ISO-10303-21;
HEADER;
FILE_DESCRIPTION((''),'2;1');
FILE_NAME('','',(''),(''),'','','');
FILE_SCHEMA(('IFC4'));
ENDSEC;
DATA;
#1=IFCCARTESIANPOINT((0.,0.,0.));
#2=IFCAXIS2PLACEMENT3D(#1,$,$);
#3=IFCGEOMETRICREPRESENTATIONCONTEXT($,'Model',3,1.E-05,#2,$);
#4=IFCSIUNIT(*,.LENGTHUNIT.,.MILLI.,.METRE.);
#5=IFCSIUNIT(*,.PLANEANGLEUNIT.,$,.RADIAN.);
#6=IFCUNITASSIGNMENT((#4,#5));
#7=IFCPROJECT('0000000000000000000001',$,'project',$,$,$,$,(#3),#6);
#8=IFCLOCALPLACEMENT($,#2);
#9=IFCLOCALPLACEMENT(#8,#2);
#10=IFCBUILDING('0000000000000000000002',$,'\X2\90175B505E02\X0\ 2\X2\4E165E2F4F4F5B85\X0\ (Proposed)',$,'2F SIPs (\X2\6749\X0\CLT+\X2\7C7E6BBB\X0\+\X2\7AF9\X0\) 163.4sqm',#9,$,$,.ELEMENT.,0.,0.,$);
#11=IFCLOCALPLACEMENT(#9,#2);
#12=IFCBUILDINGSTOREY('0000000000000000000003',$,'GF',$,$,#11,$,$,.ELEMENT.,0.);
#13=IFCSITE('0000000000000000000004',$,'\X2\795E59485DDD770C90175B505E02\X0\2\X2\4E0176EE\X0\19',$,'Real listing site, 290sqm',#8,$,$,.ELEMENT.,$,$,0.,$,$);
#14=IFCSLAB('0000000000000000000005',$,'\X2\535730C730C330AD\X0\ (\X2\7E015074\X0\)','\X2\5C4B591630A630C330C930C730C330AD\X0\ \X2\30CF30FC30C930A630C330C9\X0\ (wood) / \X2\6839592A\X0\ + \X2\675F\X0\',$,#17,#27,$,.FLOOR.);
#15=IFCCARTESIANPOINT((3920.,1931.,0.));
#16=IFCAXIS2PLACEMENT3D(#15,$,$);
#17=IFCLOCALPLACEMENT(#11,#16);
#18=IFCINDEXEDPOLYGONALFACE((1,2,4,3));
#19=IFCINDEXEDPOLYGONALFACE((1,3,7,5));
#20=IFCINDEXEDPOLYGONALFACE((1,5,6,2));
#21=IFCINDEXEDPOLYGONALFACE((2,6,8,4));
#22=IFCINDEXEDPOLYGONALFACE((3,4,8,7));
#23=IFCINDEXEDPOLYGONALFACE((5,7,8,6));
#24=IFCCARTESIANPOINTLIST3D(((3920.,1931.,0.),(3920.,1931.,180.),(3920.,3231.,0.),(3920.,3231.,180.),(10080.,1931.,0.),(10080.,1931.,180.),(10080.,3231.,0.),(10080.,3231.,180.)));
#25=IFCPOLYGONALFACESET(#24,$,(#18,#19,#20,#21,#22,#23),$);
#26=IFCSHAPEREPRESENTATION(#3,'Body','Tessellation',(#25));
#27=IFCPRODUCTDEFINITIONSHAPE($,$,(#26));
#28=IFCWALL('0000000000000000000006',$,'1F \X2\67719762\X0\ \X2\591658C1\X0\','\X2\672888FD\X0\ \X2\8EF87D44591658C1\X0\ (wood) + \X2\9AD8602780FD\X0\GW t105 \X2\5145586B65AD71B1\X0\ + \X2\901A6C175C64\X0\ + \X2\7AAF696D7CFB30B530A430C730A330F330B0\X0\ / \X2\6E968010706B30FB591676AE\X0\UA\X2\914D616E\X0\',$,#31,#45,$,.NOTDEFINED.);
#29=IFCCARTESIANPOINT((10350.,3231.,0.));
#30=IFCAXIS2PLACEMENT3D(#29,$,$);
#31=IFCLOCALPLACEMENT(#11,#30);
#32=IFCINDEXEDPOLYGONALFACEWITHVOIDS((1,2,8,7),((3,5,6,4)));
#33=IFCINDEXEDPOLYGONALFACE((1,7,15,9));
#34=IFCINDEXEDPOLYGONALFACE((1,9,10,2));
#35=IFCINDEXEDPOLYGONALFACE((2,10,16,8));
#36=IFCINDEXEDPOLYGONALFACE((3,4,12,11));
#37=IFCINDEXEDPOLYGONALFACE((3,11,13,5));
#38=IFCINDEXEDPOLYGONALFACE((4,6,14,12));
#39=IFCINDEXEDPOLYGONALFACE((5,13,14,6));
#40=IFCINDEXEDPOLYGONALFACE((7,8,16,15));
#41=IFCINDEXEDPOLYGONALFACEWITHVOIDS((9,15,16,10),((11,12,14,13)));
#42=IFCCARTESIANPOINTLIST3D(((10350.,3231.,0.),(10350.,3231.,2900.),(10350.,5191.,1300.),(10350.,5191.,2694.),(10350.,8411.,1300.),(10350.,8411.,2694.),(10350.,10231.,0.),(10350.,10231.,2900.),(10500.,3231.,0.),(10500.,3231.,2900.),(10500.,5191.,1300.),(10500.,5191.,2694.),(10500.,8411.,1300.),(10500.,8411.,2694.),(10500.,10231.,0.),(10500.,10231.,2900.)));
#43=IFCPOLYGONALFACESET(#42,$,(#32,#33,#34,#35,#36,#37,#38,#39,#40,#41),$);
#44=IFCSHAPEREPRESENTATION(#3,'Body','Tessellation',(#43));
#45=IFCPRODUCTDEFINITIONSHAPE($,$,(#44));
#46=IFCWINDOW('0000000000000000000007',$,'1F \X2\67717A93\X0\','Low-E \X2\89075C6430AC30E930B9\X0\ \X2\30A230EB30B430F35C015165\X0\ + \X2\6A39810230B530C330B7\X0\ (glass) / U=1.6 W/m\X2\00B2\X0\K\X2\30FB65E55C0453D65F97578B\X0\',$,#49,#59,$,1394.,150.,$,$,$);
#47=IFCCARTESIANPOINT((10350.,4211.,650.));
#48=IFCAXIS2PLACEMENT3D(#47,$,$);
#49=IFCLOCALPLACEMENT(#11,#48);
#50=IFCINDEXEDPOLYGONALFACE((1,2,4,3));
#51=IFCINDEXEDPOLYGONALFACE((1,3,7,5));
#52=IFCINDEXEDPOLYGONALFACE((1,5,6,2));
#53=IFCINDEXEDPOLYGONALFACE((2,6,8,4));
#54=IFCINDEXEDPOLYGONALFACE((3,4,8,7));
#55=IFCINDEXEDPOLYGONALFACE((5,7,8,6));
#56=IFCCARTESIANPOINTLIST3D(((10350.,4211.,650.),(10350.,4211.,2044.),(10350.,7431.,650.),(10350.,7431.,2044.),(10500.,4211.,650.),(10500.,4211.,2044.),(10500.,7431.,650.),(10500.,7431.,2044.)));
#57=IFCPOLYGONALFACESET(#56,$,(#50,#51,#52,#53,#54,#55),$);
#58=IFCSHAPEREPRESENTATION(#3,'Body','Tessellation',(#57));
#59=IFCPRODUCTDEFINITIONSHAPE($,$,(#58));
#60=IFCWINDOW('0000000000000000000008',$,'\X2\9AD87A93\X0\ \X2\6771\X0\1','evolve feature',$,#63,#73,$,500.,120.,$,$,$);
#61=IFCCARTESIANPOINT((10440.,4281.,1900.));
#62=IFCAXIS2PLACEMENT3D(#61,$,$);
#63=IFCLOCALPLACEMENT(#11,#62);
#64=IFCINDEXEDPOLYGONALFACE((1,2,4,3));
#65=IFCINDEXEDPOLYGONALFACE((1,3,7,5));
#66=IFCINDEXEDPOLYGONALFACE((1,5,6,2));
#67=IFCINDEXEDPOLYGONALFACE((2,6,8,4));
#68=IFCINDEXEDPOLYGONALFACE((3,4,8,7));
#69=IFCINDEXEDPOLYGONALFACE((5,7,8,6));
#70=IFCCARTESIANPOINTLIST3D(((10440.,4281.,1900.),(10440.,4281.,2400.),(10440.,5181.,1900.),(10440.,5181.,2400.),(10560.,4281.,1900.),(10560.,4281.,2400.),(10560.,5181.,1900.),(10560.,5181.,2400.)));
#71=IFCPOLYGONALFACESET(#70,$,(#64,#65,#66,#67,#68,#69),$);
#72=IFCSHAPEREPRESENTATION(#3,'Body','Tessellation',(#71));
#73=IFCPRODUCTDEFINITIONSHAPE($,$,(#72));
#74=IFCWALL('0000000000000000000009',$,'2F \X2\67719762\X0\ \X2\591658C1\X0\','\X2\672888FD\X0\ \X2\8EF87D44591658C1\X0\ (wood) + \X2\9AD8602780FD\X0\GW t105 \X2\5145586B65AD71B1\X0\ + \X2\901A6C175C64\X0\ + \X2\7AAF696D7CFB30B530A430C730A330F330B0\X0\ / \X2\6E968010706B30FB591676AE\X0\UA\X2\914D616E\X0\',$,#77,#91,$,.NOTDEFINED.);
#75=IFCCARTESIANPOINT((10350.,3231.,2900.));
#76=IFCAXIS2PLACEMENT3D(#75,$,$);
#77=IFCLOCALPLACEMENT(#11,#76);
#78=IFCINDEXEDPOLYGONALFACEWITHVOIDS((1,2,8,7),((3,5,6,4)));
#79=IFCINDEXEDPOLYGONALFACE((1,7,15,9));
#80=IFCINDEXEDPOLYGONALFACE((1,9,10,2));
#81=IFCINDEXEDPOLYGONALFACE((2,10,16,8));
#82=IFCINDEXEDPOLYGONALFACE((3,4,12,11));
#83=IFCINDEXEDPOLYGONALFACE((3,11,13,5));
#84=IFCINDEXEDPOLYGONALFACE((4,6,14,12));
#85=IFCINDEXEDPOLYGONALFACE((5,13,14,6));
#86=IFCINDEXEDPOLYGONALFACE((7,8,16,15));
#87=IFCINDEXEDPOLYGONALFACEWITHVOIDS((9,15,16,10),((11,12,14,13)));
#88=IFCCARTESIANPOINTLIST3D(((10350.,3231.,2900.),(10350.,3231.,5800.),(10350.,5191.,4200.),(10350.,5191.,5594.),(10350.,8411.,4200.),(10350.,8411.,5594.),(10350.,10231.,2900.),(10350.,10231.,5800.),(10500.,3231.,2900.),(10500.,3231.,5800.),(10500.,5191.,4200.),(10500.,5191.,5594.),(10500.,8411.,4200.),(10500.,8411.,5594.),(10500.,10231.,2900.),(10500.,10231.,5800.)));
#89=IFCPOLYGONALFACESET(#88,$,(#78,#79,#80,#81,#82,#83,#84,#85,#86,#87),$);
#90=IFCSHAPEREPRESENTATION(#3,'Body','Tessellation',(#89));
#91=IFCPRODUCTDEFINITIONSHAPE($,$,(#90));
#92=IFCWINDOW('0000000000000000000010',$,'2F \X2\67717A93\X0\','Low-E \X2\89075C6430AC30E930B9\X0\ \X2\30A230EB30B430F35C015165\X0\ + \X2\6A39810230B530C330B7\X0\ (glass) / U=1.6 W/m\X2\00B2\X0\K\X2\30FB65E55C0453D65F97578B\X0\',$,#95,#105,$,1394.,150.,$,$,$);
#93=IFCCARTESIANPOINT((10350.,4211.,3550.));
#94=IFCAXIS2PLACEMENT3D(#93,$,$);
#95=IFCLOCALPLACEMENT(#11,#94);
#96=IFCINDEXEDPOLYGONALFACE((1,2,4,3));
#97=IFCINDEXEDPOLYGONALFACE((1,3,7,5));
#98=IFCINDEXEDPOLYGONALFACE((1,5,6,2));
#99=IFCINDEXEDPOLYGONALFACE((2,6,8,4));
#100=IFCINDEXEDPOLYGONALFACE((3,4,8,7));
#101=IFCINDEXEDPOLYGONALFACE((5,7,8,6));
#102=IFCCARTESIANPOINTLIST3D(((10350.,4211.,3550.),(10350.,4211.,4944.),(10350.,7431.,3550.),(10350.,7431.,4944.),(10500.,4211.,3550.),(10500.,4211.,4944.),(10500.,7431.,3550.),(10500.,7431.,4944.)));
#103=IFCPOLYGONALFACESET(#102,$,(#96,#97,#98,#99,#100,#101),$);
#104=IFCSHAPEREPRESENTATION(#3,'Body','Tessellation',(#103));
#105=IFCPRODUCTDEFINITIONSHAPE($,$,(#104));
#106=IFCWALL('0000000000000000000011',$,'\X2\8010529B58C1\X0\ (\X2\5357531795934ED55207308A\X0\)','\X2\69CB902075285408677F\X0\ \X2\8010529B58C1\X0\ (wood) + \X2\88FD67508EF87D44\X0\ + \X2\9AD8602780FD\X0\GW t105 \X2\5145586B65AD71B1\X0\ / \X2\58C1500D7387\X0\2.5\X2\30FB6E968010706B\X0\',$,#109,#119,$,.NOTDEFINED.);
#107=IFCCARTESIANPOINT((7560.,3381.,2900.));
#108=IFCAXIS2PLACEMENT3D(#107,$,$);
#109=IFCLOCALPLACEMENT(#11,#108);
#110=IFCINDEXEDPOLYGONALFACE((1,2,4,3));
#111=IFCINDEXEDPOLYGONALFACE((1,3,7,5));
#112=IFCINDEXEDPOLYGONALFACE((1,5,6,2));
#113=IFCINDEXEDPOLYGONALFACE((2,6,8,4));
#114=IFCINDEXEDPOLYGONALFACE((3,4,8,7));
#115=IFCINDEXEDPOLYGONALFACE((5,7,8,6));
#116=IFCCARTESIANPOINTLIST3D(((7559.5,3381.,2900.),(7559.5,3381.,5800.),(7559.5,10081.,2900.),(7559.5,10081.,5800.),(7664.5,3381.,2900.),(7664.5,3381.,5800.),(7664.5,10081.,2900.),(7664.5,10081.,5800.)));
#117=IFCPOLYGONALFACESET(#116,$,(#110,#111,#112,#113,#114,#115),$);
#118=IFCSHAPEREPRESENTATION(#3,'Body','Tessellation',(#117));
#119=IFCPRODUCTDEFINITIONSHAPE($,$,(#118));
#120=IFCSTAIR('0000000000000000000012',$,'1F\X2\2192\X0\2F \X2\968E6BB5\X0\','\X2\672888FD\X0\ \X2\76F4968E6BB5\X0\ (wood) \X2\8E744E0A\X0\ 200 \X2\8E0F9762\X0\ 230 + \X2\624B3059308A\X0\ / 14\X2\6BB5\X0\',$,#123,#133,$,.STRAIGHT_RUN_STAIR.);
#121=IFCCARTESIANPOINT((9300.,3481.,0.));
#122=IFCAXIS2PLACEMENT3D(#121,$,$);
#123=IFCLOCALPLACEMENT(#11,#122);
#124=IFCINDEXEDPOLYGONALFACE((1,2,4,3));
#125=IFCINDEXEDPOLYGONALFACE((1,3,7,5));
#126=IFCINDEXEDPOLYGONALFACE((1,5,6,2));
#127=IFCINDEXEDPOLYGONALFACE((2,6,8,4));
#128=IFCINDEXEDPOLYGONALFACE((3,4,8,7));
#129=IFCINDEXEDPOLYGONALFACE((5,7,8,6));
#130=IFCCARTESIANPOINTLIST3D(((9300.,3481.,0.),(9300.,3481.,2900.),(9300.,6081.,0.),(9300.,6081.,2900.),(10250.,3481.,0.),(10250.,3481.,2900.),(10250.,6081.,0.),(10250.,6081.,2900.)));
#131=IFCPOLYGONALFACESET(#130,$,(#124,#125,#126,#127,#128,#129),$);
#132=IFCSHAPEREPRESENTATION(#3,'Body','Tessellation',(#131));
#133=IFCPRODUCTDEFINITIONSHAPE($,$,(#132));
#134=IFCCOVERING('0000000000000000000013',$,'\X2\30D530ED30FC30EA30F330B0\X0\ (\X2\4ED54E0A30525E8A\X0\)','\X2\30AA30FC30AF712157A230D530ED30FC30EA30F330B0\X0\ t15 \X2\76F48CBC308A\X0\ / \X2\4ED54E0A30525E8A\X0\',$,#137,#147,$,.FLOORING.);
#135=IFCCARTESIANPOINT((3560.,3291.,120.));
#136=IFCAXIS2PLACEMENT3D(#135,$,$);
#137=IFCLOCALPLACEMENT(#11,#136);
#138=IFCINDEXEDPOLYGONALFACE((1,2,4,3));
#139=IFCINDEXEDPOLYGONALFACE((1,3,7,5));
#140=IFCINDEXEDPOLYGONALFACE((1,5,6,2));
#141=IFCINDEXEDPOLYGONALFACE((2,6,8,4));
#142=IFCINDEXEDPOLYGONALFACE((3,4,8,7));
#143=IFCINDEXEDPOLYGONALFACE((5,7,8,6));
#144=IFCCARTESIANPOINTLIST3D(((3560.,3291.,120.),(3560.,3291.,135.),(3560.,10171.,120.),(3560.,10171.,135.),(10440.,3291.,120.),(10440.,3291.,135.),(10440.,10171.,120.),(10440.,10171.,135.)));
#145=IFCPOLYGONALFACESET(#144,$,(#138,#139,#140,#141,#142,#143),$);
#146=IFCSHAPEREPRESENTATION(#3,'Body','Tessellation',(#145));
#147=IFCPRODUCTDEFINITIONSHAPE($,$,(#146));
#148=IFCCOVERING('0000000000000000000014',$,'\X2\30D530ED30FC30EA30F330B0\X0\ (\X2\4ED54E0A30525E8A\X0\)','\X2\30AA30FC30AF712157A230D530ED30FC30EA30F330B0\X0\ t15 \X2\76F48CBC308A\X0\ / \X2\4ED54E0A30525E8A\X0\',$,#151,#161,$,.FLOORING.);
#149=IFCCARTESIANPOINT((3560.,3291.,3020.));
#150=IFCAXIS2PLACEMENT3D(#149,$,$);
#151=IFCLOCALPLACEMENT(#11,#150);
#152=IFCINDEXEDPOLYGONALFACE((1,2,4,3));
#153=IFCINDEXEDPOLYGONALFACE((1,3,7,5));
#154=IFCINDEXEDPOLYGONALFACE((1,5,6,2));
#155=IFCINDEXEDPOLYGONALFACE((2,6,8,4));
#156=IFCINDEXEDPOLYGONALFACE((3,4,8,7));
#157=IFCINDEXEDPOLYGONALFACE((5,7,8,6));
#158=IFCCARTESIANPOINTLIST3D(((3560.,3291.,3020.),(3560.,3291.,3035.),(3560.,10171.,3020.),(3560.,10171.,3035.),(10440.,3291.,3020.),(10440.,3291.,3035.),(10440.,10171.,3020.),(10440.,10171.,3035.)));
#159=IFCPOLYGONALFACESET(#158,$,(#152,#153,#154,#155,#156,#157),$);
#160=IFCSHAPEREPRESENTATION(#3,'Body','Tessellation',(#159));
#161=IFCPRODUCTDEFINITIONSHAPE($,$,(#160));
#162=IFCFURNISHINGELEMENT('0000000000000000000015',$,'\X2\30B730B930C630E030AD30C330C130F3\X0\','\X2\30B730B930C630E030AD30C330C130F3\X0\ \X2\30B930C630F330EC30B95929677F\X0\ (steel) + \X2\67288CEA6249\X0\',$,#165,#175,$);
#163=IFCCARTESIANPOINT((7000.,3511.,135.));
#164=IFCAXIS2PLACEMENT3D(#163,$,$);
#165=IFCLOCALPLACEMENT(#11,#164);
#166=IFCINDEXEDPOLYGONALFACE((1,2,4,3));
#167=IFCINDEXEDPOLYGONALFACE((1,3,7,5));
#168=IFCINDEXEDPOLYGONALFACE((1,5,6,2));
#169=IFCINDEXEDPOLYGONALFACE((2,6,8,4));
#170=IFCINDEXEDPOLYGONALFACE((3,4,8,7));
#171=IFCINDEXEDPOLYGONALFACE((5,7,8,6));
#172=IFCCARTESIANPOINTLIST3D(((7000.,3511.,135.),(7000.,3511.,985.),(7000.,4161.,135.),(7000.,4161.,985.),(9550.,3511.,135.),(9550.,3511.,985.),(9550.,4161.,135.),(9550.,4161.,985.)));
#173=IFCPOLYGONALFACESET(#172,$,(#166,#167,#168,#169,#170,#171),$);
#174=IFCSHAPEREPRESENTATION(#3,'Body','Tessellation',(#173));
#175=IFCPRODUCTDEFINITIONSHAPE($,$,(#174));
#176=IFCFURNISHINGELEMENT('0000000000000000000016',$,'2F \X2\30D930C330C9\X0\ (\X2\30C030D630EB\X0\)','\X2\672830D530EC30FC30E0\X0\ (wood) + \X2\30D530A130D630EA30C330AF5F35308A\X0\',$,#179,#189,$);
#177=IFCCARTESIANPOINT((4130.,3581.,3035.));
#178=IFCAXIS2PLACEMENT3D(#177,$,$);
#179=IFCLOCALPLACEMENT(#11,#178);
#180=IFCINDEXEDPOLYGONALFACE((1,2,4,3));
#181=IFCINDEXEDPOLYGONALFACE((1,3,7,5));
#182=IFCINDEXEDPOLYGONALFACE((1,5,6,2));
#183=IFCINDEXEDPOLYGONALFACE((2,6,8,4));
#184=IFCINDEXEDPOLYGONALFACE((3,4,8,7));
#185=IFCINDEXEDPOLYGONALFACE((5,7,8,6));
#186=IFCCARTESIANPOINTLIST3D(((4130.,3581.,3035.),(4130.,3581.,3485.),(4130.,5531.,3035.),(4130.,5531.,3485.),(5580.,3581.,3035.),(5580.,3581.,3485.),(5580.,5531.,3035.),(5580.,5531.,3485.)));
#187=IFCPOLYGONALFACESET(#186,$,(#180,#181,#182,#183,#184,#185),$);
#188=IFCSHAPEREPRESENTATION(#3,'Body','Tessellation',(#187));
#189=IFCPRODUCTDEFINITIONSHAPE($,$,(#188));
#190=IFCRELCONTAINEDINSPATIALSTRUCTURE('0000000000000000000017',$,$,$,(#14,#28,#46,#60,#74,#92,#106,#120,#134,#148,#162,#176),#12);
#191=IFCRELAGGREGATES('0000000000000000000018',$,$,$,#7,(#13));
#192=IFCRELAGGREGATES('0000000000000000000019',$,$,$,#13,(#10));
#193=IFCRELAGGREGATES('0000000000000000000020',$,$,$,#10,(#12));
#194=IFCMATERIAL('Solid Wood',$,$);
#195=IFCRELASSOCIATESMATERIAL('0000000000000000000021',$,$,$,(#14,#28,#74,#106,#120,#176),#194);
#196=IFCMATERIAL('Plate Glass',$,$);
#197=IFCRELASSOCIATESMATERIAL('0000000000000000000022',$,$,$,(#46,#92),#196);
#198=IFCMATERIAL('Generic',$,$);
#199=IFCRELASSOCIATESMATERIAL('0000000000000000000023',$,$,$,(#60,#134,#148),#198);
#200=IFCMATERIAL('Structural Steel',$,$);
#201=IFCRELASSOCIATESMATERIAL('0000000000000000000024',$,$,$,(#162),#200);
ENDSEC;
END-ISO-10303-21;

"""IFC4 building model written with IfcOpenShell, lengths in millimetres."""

from ifc_helpers import new_model, si_unit, frame, frame_2d, origin, place, context, project, spatial, rectangle, extrude, material, element, fill, save


model = new_model("IFC4")

# Units and contexts
model_context = context("Model", 3, precision=1e-05, world=origin())
ifc_project = project(units=[si_unit("LENGTHUNIT", "METRE", prefix="MILLI"), si_unit("PLANEANGLEUNIT", "RADIAN")], contexts=[model_context])

# Site, building, storey
site_placement = place(None, origin())
site = spatial("IfcSite", under=ifc_project, at=site_placement, Name="神奈川県逗子市2丁目19", ObjectType="Real listing site, 290sqm", CompositionType="ELEMENT", RefElevation=0.0)
building_placement = place(site_placement, origin())
building = spatial("IfcBuilding", under=site, at=building_placement, Name="逗子市 2世帯住宅 (Proposed)", ObjectType="2F SIPs (杉CLT+籾殻+竹) 163.4sqm", CompositionType="ELEMENT", ElevationOfRefHeight=0.0, ElevationOfTerrain=0.0)
storey_placement = place(building_placement, origin())
storey = spatial("IfcBuildingStorey", under=building, at=storey_placement, Name="GF", CompositionType="ELEMENT", Elevation=0.0)

# Slab
ifc_material_1 = material(Name="Solid Wood")
slab_placement = place(storey_placement, frame((3920.0, 1931.0, 0.0)))
element("IfcSlab", 1, at=slab_placement, inside=storey, material=ifc_material_1, Name="南デッキ (縁側)", Description="屋外ウッドデッキ ハードウッド (wood) / 根太 + 束", PredefinedType="FLOOR", context=model_context, shape_type="SweptSolid", body=[
    extrude(rectangle(XDim=6160.0, YDim=1300.0, at=frame_2d((3080.0, 650.0))), frame((3920.0, 1931.0, 0.0)), (0.0, 0.0, 1.0), 180.0),
])

# Wall, openings, windows
wall_1_placement = place(storey_placement, frame((10350.0, 3231.0, 0.0)))
wall_1 = element("IfcWall", 2, at=wall_1_placement, inside=storey, material=ifc_material_1, Name="1F 東面 外壁", Description="木製 軸組外壁 (wood) + 高性能GW t105 充填断熱 + 通気層 + 窯業系サイディング / 準耐火・外皮UA配慮", PredefinedType="NOTDEFINED", context=model_context, shape_type="SweptSolid", body=[
    extrude(rectangle(XDim=150.0, YDim=7000.0, at=frame_2d((75.0, 3500.0))), frame((10350.0, 3231.0, 0.0)), (0.0, 0.0, 1.0), 2900.0),
])
opening_1_placement = place(storey_placement, frame((10350.0, 4211.0, 650.0)))
opening_1 = element("IfcOpeningElement", 3, at=opening_1_placement, cuts=wall_1, PredefinedType="NOTDEFINED", context=model_context, shape_type="SweptSolid", body=[
    extrude(rectangle(XDim=150.0, YDim=3220.0, at=frame_2d((75.0, 1610.0))), frame((10350.0, 4211.0, 650.0)), (0.0, 0.0, 1.0), 1394.0),
])
opening_2_placement = place(storey_placement, frame((10440.0, 4281.0, 1900.0)))
opening_2 = element("IfcOpeningElement", 4, at=opening_2_placement, cuts=wall_1, PredefinedType="NOTDEFINED", context=model_context, shape_type="SweptSolid", body=[
    extrude(rectangle(XDim=120.0, YDim=900.0, at=frame_2d((60.0, 450.0))), frame((10440.0, 4281.0, 1900.0)), (0.0, 0.0, 1.0), 500.0),
])
ifc_material_2 = material(Name="Plate Glass")
window_1_placement = place(storey_placement, frame((10350.0, 4211.0, 650.0)))
window_1 = element("IfcWindow", 5, at=window_1_placement, inside=storey, material=ifc_material_2, Name="1F 東窓", Description="Low-E 複層ガラス アルゴン封入 + 樹脂サッシ (glass) / U=1.6 W/m²K・日射取得型", OverallHeight=1394.0, OverallWidth=150.0, context=model_context, shape_type="SweptSolid", body=[
    extrude(rectangle(XDim=150.0, YDim=3220.0, at=frame_2d((75.0, 1610.0))), frame((10350.0, 4211.0, 650.0)), (0.0, 0.0, 1.0), 1394.0),
])
fill(opening_1, window_1)
ifc_material_3 = material(Name="Generic")
window_2_placement = place(storey_placement, frame((10440.0, 4281.0, 1900.0)))
window_2 = element("IfcWindow", 6, at=window_2_placement, inside=storey, material=ifc_material_3, Name="高窓 東1", Description="evolve feature", OverallHeight=500.0, OverallWidth=120.0, context=model_context, shape_type="SweptSolid", body=[
    extrude(rectangle(XDim=120.0, YDim=900.0, at=frame_2d((60.0, 450.0))), frame((10440.0, 4281.0, 1900.0)), (0.0, 0.0, 1.0), 500.0),
])
fill(opening_2, window_2)

# Wall, opening, window
wall_2_placement = place(storey_placement, frame((10350.0, 3231.0, 2900.0)))
wall_2 = element("IfcWall", 7, at=wall_2_placement, inside=storey, material=ifc_material_1, Name="2F 東面 外壁", Description="木製 軸組外壁 (wood) + 高性能GW t105 充填断熱 + 通気層 + 窯業系サイディング / 準耐火・外皮UA配慮", PredefinedType="NOTDEFINED", context=model_context, shape_type="SweptSolid", body=[
    extrude(rectangle(XDim=150.0, YDim=7000.0, at=frame_2d((75.0, 3500.0))), frame((10350.0, 3231.0, 2900.0)), (0.0, 0.0, 1.0), 2900.0),
])
opening_3_placement = place(storey_placement, frame((10350.0, 4211.0, 3550.0)))
opening_3 = element("IfcOpeningElement", 8, at=opening_3_placement, cuts=wall_2, PredefinedType="NOTDEFINED", context=model_context, shape_type="SweptSolid", body=[
    extrude(rectangle(XDim=150.0, YDim=3220.0, at=frame_2d((75.0, 1610.0))), frame((10350.0, 4211.0, 3550.0)), (0.0, 0.0, 1.0), 1394.0),
])
window_3_placement = place(storey_placement, frame((10350.0, 4211.0, 3550.0)))
window_3 = element("IfcWindow", 9, at=window_3_placement, inside=storey, material=ifc_material_2, Name="2F 東窓", Description="Low-E 複層ガラス アルゴン封入 + 樹脂サッシ (glass) / U=1.6 W/m²K・日射取得型", OverallHeight=1394.0, OverallWidth=150.0, context=model_context, shape_type="SweptSolid", body=[
    extrude(rectangle(XDim=150.0, YDim=3220.0, at=frame_2d((75.0, 1610.0))), frame((10350.0, 4211.0, 3550.0)), (0.0, 0.0, 1.0), 1394.0),
])
fill(opening_3, window_3)

# Wall
wall_3_placement = place(storey_placement, frame((7560.0, 3381.0, 2900.0)))
element("IfcWall", 10, at=wall_3_placement, inside=storey, material=ifc_material_1, Name="耐力壁 (南北間仕切り)", Description="構造用合板 耐力壁 (wood) + 製材軸組 + 高性能GW t105 充填断熱 / 壁倍率2.5・準耐火", PredefinedType="NOTDEFINED", context=model_context, shape_type="SweptSolid", body=[
    extrude(rectangle(XDim=105.0, YDim=6700.0, at=frame_2d((52.0, 3350.0))), frame((7560.0, 3381.0, 2900.0)), (0.0, 0.0, 1.0), 2900.0),
])

# Stair
stair_placement = place(storey_placement, frame((9300.0, 3481.0, 0.0)))
element("IfcStair", 11, at=stair_placement, inside=storey, material=ifc_material_1, Name="1F→2F 階段", Description="木製 直階段 (wood) 蹴上 200 踏面 230 + 手すり / 14段", PredefinedType="STRAIGHT_RUN_STAIR", context=model_context, shape_type="SweptSolid", body=[
    extrude(rectangle(XDim=950.0, YDim=2600.0, at=frame_2d((475.0, 1300.0))), frame((9300.0, 3481.0, 0.0)), (0.0, 0.0, 1.0), 2900.0),
])

# Coverings
covering_1_placement = place(storey_placement, frame((3560.0, 3291.0, 120.0)))
element("IfcCovering", 12, at=covering_1_placement, inside=storey, material=ifc_material_3, Name="フローリング (仕上げ床)", Description="オーク無垢フローリング t15 直貼り / 仕上げ床", PredefinedType="FLOORING", context=model_context, shape_type="SweptSolid", body=[
    extrude(rectangle(XDim=6880.0, YDim=6880.0, at=frame_2d((3440.0, 3440.0))), frame((3560.0, 3291.0, 120.0)), (0.0, 0.0, 1.0), 15.0),
])
covering_2_placement = place(storey_placement, frame((3560.0, 3291.0, 3020.0)))
element("IfcCovering", 13, at=covering_2_placement, inside=storey, material=ifc_material_3, Name="フローリング (仕上げ床)", Description="オーク無垢フローリング t15 直貼り / 仕上げ床", PredefinedType="FLOORING", context=model_context, shape_type="SweptSolid", body=[
    extrude(rectangle(XDim=6880.0, YDim=6880.0, at=frame_2d((3440.0, 3440.0))), frame((3560.0, 3291.0, 3020.0)), (0.0, 0.0, 1.0), 15.0),
])

# Furnishing elements
ifc_material_4 = material(Name="Structural Steel")
furnishing_1_placement = place(storey_placement, frame((7000.0, 3511.0, 135.0)))
element("IfcFurnishingElement", 14, at=furnishing_1_placement, inside=storey, material=ifc_material_4, Name="システムキッチン", Description="システムキッチン ステンレス天板 (steel) + 木質扉", context=model_context, shape_type="SweptSolid", body=[
    extrude(rectangle(XDim=2550.0, YDim=650.0, at=frame_2d((1275.0, 325.0))), frame((7000.0, 3511.0, 135.0)), (0.0, 0.0, 1.0), 850.0),
])
furnishing_2_placement = place(storey_placement, frame((4130.0, 3581.0, 3035.0)))
element("IfcFurnishingElement", 15, at=furnishing_2_placement, inside=storey, material=ifc_material_1, Name="2F ベッド (ダブル)", Description="木フレーム (wood) + ファブリック張り", context=model_context, shape_type="SweptSolid", body=[
    extrude(rectangle(XDim=1450.0, YDim=1950.0, at=frame_2d((725.0, 975.0))), frame((4130.0, 3581.0, 3035.0)), (0.0, 0.0, 1.0), 450.0),
])

save(model, "model.ifc")
